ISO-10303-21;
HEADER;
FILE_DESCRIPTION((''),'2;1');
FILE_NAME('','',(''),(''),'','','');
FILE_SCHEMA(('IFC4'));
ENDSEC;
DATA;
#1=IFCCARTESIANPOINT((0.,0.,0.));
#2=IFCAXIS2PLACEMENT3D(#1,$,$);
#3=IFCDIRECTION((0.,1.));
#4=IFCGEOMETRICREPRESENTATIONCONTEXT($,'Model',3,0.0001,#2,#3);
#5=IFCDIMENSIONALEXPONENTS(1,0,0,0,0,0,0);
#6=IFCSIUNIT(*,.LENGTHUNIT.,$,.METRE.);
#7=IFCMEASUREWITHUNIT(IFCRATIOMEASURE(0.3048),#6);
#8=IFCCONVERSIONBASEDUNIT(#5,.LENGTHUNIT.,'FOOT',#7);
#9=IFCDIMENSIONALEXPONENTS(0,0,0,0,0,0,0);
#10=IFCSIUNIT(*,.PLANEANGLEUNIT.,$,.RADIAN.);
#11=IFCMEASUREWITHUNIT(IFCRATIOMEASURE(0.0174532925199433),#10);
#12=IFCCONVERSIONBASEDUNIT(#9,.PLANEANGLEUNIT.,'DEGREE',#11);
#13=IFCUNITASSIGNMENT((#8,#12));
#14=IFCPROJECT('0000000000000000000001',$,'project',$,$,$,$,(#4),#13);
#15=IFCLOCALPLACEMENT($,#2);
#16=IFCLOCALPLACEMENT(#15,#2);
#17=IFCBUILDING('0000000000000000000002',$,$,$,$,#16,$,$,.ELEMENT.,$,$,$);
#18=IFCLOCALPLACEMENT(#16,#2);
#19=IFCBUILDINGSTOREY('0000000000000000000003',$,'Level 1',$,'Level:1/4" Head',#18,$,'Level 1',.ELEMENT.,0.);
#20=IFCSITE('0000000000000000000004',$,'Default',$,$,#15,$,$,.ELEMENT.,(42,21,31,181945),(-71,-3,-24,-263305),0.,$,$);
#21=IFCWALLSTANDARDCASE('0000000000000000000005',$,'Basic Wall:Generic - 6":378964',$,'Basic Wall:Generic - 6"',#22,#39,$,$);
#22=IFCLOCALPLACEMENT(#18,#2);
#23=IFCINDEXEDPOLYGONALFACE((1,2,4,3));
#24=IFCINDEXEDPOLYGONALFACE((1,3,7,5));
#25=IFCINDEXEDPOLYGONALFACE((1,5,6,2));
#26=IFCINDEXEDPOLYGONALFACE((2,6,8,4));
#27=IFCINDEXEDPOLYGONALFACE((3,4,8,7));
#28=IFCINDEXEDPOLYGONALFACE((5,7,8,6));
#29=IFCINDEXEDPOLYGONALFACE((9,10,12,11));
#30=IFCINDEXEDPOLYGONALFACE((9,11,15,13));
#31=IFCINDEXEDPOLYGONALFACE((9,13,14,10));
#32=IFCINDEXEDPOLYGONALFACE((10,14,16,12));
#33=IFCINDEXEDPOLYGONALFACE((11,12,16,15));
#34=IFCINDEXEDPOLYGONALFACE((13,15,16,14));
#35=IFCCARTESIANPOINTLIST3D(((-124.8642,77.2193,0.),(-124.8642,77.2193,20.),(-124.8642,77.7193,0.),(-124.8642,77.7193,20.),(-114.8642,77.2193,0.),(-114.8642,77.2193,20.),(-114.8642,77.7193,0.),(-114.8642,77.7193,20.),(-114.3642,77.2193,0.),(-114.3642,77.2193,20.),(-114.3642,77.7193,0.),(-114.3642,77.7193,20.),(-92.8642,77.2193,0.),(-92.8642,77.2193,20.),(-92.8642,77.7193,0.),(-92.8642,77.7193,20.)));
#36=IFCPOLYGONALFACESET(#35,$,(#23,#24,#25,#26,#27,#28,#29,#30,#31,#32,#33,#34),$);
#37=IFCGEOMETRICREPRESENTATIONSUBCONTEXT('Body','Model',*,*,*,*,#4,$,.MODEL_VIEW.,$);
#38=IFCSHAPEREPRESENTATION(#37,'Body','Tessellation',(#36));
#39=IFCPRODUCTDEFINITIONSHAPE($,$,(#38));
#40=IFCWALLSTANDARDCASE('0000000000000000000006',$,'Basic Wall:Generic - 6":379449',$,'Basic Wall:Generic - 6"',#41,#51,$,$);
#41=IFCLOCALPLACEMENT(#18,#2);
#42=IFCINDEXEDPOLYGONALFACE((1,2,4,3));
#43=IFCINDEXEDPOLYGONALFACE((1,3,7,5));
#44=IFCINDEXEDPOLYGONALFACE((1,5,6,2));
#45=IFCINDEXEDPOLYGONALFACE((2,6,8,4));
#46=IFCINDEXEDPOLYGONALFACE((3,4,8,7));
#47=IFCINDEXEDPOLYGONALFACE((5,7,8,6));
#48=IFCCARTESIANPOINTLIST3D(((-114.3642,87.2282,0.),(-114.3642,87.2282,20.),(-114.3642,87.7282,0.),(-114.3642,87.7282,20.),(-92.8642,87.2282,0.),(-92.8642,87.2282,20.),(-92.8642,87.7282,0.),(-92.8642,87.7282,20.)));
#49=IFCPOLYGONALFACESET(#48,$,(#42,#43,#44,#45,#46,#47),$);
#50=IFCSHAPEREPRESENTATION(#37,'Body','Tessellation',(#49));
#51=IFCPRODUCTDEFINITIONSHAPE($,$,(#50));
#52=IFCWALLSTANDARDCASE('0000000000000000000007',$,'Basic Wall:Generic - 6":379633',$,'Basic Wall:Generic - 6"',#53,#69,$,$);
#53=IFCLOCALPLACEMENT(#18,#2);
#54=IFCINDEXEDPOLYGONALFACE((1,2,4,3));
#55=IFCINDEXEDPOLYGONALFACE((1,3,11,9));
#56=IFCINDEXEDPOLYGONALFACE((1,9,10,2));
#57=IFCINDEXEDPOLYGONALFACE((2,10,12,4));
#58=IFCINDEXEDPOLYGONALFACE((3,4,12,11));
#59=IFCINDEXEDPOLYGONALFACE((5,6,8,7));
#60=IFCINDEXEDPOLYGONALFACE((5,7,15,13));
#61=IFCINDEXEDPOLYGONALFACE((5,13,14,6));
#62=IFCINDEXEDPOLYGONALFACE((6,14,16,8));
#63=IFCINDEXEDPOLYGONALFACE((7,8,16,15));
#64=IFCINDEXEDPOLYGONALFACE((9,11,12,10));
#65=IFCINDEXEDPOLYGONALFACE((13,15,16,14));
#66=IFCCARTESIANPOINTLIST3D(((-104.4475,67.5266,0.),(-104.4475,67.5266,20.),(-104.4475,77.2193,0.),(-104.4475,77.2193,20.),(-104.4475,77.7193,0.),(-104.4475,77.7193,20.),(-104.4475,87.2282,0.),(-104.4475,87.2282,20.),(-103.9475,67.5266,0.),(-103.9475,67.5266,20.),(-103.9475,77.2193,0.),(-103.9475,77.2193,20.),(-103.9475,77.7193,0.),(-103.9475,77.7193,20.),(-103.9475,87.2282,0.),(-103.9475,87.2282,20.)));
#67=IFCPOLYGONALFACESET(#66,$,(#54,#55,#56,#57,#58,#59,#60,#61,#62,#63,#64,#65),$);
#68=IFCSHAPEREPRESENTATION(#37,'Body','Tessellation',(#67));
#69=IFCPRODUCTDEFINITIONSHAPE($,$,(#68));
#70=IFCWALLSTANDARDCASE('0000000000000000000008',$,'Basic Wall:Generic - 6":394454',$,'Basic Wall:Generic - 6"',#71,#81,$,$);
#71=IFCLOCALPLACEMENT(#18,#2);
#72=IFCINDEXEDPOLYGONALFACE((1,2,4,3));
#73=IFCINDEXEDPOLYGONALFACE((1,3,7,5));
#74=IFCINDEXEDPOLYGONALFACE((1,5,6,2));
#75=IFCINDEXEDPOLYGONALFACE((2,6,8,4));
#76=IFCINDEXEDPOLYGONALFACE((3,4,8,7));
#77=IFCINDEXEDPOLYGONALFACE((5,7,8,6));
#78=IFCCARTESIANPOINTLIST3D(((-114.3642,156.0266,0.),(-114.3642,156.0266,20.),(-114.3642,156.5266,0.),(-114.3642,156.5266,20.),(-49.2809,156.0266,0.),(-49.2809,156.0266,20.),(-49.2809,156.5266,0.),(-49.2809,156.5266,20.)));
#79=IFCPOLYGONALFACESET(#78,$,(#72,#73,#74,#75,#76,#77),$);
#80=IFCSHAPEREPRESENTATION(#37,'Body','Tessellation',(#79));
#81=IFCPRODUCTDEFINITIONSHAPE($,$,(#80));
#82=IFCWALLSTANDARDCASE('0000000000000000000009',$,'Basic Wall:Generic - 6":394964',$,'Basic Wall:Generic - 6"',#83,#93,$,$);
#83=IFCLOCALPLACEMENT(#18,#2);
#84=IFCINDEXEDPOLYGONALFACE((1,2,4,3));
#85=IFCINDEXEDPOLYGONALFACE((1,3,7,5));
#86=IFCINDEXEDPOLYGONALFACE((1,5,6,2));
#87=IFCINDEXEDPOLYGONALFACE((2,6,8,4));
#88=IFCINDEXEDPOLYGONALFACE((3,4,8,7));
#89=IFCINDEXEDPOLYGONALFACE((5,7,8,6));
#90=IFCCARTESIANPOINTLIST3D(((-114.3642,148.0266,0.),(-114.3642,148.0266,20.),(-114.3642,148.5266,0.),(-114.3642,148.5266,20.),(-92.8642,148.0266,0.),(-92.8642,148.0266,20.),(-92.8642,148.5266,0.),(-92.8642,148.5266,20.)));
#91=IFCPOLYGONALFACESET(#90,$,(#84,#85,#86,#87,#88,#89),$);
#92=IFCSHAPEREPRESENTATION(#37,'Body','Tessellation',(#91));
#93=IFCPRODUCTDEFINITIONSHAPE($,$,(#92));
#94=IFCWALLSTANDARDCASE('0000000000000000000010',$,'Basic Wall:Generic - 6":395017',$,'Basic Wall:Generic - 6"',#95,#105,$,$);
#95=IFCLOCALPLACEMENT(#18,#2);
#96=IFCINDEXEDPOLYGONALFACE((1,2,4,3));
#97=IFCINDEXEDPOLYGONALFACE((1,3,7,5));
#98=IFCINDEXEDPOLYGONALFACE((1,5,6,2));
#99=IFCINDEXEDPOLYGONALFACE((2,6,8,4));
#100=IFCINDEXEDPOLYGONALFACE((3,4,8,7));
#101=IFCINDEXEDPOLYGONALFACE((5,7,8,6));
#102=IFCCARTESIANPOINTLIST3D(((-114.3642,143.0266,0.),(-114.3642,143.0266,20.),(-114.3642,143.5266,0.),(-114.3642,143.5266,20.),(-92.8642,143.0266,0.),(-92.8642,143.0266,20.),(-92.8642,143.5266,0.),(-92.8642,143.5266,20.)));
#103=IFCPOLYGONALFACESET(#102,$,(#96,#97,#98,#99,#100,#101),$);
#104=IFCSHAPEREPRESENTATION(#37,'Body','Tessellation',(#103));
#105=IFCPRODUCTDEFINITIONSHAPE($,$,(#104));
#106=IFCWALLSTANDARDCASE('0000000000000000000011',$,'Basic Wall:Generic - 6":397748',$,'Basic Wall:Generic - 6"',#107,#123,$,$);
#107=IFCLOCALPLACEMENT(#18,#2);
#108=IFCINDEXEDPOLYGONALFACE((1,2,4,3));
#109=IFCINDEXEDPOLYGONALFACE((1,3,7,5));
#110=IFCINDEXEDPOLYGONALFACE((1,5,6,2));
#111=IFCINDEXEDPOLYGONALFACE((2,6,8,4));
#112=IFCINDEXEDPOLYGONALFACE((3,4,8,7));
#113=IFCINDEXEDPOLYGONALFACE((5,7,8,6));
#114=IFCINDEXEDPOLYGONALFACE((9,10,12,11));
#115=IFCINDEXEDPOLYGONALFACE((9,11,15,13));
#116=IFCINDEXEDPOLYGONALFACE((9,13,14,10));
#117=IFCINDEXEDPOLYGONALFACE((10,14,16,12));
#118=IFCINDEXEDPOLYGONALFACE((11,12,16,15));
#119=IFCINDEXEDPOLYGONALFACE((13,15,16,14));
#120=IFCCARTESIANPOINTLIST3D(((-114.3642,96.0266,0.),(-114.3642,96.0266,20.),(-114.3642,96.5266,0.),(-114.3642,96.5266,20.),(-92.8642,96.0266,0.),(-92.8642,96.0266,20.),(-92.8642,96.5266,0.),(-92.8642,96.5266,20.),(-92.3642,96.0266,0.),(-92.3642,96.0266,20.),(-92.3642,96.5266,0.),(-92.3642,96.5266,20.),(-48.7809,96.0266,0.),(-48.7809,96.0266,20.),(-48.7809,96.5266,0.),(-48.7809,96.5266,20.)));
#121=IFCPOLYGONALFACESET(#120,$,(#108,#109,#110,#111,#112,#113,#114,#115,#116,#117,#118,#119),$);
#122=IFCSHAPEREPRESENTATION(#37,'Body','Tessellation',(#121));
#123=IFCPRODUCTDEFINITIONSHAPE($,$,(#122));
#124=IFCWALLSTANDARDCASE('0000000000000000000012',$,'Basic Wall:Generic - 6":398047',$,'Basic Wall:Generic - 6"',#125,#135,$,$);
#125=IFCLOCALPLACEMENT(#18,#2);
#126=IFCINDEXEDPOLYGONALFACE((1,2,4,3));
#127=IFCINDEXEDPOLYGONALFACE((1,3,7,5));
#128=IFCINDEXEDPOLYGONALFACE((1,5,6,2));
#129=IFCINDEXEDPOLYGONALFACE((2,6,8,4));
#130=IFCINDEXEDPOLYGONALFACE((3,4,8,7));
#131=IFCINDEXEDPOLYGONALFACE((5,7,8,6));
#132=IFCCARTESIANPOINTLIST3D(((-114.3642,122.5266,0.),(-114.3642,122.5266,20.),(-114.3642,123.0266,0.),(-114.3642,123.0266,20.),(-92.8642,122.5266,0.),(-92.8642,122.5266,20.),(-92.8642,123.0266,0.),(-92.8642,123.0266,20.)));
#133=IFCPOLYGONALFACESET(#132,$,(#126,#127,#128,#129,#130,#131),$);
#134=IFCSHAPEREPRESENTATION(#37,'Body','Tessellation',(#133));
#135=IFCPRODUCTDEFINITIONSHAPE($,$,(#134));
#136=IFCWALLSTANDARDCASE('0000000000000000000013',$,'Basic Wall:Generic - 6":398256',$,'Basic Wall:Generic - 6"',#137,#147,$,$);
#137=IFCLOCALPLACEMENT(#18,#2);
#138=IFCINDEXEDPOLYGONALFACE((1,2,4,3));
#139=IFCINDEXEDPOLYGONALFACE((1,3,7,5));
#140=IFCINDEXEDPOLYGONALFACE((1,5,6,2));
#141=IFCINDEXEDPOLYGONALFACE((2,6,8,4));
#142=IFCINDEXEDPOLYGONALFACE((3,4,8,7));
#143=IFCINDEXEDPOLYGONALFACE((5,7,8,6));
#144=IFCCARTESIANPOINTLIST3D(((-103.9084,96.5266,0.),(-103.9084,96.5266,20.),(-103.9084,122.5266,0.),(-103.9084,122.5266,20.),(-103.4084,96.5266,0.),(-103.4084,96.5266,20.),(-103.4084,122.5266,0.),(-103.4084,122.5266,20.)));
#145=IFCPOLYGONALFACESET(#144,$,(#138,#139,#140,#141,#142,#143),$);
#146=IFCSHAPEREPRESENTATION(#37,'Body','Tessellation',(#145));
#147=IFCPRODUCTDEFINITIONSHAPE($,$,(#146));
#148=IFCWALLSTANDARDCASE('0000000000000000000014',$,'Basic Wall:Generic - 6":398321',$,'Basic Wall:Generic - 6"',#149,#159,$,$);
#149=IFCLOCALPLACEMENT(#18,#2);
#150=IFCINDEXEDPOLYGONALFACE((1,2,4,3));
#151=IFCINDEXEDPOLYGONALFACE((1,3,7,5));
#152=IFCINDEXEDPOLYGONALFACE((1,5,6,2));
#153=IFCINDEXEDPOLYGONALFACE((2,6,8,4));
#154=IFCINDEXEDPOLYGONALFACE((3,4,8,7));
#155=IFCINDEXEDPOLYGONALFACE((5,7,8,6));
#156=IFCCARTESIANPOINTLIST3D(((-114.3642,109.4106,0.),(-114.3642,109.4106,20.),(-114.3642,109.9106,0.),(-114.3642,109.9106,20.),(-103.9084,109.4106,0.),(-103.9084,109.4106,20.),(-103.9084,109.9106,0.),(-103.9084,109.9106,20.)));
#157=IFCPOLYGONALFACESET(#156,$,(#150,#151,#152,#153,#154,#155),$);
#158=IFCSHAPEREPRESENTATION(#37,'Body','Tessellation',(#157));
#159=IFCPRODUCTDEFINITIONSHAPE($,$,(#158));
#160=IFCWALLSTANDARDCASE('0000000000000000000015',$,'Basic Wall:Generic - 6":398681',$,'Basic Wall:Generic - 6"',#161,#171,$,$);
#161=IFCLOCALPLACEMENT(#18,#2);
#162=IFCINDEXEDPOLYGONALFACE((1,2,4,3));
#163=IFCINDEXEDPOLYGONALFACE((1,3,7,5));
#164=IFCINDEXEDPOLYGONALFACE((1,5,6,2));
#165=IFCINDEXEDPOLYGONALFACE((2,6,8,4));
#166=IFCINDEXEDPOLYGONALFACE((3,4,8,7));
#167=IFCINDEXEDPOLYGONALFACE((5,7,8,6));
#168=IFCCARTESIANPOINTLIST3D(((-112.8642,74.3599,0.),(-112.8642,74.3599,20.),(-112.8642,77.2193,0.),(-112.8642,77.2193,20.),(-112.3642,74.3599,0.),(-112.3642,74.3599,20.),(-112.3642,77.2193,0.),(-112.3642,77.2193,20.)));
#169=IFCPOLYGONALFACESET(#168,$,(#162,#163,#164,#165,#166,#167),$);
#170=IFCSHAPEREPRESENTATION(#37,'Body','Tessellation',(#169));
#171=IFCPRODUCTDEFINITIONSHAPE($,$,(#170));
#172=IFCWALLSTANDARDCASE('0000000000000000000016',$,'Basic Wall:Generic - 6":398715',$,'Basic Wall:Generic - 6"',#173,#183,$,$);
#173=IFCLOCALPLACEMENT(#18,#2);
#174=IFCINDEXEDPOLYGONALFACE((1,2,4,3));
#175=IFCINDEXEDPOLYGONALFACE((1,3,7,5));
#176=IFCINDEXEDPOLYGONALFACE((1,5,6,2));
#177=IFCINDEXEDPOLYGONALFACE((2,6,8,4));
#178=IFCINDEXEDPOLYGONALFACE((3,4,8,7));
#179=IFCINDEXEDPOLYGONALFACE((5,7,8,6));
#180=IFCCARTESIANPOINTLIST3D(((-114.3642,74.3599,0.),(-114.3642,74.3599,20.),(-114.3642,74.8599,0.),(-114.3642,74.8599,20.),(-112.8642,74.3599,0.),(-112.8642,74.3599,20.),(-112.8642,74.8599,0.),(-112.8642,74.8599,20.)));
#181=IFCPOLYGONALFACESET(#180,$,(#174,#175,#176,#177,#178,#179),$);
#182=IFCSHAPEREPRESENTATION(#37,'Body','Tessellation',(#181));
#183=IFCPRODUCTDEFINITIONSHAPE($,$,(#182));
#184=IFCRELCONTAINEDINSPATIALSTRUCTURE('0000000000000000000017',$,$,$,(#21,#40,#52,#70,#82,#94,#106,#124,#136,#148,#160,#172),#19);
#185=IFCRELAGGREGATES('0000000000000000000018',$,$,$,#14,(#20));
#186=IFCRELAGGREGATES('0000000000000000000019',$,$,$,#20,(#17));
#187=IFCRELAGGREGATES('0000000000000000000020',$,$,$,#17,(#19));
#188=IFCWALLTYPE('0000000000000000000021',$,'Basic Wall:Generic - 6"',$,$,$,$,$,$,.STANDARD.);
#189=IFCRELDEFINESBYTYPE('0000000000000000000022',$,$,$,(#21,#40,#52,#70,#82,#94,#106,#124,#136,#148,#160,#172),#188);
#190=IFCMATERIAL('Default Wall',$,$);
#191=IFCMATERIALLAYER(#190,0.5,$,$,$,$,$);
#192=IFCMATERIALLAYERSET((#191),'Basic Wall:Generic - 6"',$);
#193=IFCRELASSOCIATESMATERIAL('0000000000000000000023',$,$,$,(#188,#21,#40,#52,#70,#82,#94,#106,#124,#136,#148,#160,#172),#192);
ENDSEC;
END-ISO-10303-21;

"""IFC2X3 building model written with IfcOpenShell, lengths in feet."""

from ifc_helpers import new_model, entity, si_unit, converted_unit, direction, frame, frame_2d, origin, origin_2d_with_axis, place, context, subcontext, project, spatial, rectangle, extrude, material, layer, layer_set, layer_usage, type_object, element, save


model = new_model("IFC2X3")

# Units and contexts
model_context = context("Model", 3, precision=0.0001, world=origin(), true_north=direction((0.0, 1.0)))
body_context = subcontext(model_context, "Body", "Model", "MODEL_VIEW")
ifc_project = project(units=[converted_unit("LENGTHUNIT", "FOOT", entity("IfcRatioMeasure", 0.3048), si_unit("LENGTHUNIT", "METRE"), dimensions=[1, 0, 0, 0, 0, 0, 0]), converted_unit("PLANEANGLEUNIT", "DEGREE", entity("IfcRatioMeasure", 0.0174532925199433), si_unit("PLANEANGLEUNIT", "RADIAN"), dimensions=[0, 0, 0, 0, 0, 0, 0])], contexts=[model_context])

# Site, building, storey
site_placement = place(None, origin())
site = spatial("IfcSite", under=ifc_project, at=site_placement, Name="Default", CompositionType="ELEMENT", RefLatitude=(42, 21, 31, 181945), RefLongitude=(-71, -3, -24, -263305), RefElevation=0.0)
building_placement = place(site_placement, origin())
building = spatial("IfcBuilding", under=site, at=building_placement, CompositionType="ELEMENT")
storey_placement = place(building_placement, origin())
storey = spatial("IfcBuildingStorey", under=building, at=storey_placement, Name="Level 1", ObjectType="Level:1/4\" Head", LongName="Level 1", CompositionType="ELEMENT", Elevation=0.0)

# Shared definitions
ifc_material = material(Name="Default Wall")
ifc_layer_1 = layer(ifc_material, 0.5)
ifc_layer_set_1 = layer_set([ifc_layer_1], Name="Basic Wall:Generic - 6\"")
wall_type_1 = type_object("IfcWallType", Name="Basic Wall:Generic - 6\"", PredefinedType="STANDARD", material=ifc_layer_set_1)

# Wall, opening
ifc_layer_usage_1 = layer_usage(ifc_layer_set_1, "AXIS2", "NEGATIVE", 0.25)
wall_1_placement = place(storey_placement, frame((-124.8642, 77.4693, 0.0)))
wall_1 = element("IfcWallStandardCase", 1, at=wall_1_placement, inside=storey, type_object=wall_type_1, material=ifc_layer_usage_1, Name="Basic Wall:Generic - 6\":378964", ObjectType="Basic Wall:Generic - 6\"", context=body_context, shape_type="SweptSolid", body=[
    extrude(rectangle(XDim=32.0, YDim=0.5, at=frame_2d((16.0, 0.0), x_axis=(-1.0, 0.0))), origin(), (0.0, 0.0, 1.0), 20.0),
])
opening_1_placement = place(storey_placement, frame((-124.8642, 77.4693, 0.0)))
element("IfcOpeningElement", 2, at=opening_1_placement, cuts=wall_1, ObjectType="Opening", context=body_context, shape_type="SweptSolid", body=[
    extrude(rectangle(XDim=20.0, YDim=0.5, at=origin_2d_with_axis()), frame((10.0, 0.0, 10.0), z_axis=(1.0, 0.0, 0.0), x_axis=(0.0, 0.0, -1.0)), (0.0, 0.0, 1.0), 0.5),
])

# Wall
ifc_layer_usage_2 = layer_usage(ifc_layer_set_1, "AXIS2", "NEGATIVE", 0.25)
wall_2_placement = place(storey_placement, frame((-114.3642, 87.4782, 0.0)))
element("IfcWallStandardCase", 3, at=wall_2_placement, inside=storey, type_object=wall_type_1, material=ifc_layer_usage_2, Name="Basic Wall:Generic - 6\":379449", ObjectType="Basic Wall:Generic - 6\"", context=body_context, shape_type="SweptSolid", body=[
    extrude(rectangle(XDim=21.5, YDim=0.5, at=frame_2d((10.75, 0.0), x_axis=(-1.0, 0.0))), origin(), (0.0, 0.0, 1.0), 20.0),
])

# Wall, opening
ifc_layer_usage_3 = layer_usage(ifc_layer_set_1, "AXIS2", "NEGATIVE", 0.25)
wall_3_placement = place(storey_placement, frame((-104.1975, 67.5266, 0.0), z_axis=(0.0, 0.0, 1.0), x_axis=(0.0, 1.0, 0.0)))
wall_3 = element("IfcWallStandardCase", 4, at=wall_3_placement, inside=storey, type_object=wall_type_1, material=ifc_layer_usage_3, Name="Basic Wall:Generic - 6\":379633", ObjectType="Basic Wall:Generic - 6\"", context=body_context, shape_type="SweptSolid", body=[
    extrude(rectangle(XDim=19.7016, YDim=0.5, at=frame_2d((9.8508, 0.0), x_axis=(-1.0, 0.0))), origin(), (0.0, 0.0, 1.0), 20.0),
])
opening_2_placement = place(storey_placement, frame((-104.1975, 67.5266, 0.0), z_axis=(0.0, 0.0, 1.0), x_axis=(0.0, 1.0, 0.0)))
element("IfcOpeningElement", 5, at=opening_2_placement, cuts=wall_3, ObjectType="Opening", context=body_context, shape_type="SweptSolid", body=[
    extrude(rectangle(XDim=20.0, YDim=0.5, at=origin_2d_with_axis()), frame((9.6927, 0.0, 10.0), z_axis=(1.0, 0.0, 0.0), x_axis=(0.0, 0.0, -1.0)), (0.0, 0.0, 1.0), 0.5),
])

# Walls
ifc_layer_usage_4 = layer_usage(ifc_layer_set_1, "AXIS2", "NEGATIVE", 0.25)
wall_4_placement = place(storey_placement, frame((-114.3642, 156.2766, 0.0)))
element("IfcWallStandardCase", 6, at=wall_4_placement, inside=storey, type_object=wall_type_1, material=ifc_layer_usage_4, Name="Basic Wall:Generic - 6\":394454", ObjectType="Basic Wall:Generic - 6\"", context=body_context, shape_type="SweptSolid", body=[
    extrude(rectangle(XDim=65.0833, YDim=0.5, at=frame_2d((32.5417, 0.0), x_axis=(-1.0, 0.0))), origin(), (0.0, 0.0, 1.0), 20.0),
])
ifc_layer_usage_5 = layer_usage(ifc_layer_set_1, "AXIS2", "NEGATIVE", 0.25)
wall_5_placement = place(storey_placement, frame((-114.3642, 148.2766, 0.0)))
element("IfcWallStandardCase", 7, at=wall_5_placement, inside=storey, type_object=wall_type_1, material=ifc_layer_usage_5, Name="Basic Wall:Generic - 6\":394964", ObjectType="Basic Wall:Generic - 6\"", context=body_context, shape_type="SweptSolid", body=[
    extrude(rectangle(XDim=21.5, YDim=0.5, at=frame_2d((10.75, 0.0), x_axis=(-1.0, 0.0))), origin(), (0.0, 0.0, 1.0), 20.0),
])
ifc_layer_usage_6 = layer_usage(ifc_layer_set_1, "AXIS2", "NEGATIVE", 0.25)
wall_6_placement = place(storey_placement, frame((-114.3642, 143.2766, 0.0)))
element("IfcWallStandardCase", 8, at=wall_6_placement, inside=storey, type_object=wall_type_1, material=ifc_layer_usage_6, Name="Basic Wall:Generic - 6\":395017", ObjectType="Basic Wall:Generic - 6\"", context=body_context, shape_type="SweptSolid", body=[
    extrude(rectangle(XDim=21.5, YDim=0.5, at=frame_2d((10.75, 0.0), x_axis=(-1.0, 0.0))), origin(), (0.0, 0.0, 1.0), 20.0),
])

# Wall, opening
ifc_layer_usage_7 = layer_usage(ifc_layer_set_1, "AXIS2", "NEGATIVE", 0.25)
wall_7_placement = place(storey_placement, frame((-114.3642, 96.2766, 0.0)))
wall_7 = element("IfcWallStandardCase", 9, at=wall_7_placement, inside=storey, type_object=wall_type_1, material=ifc_layer_usage_7, Name="Basic Wall:Generic - 6\":397748", ObjectType="Basic Wall:Generic - 6\"", context=body_context, shape_type="SweptSolid", body=[
    extrude(rectangle(XDim=65.5833, YDim=0.5, at=frame_2d((32.7917, 0.0), x_axis=(-1.0, 0.0))), origin(), (0.0, 0.0, 1.0), 20.0),
])
opening_3_placement = place(storey_placement, frame((-114.3642, 96.2766, 0.0)))
element("IfcOpeningElement", 10, at=opening_3_placement, cuts=wall_7, ObjectType="Opening", context=body_context, shape_type="SweptSolid", body=[
    extrude(rectangle(XDim=20.0, YDim=0.5, at=origin_2d_with_axis()), frame((21.5, 0.0, 10.0), z_axis=(1.0, 0.0, 0.0), x_axis=(0.0, 0.0, -1.0)), (0.0, 0.0, 1.0), 0.5),
])

# Walls
ifc_layer_usage_8 = layer_usage(ifc_layer_set_1, "AXIS2", "NEGATIVE", 0.25)
wall_8_placement = place(storey_placement, frame((-114.3642, 122.7766, 0.0)))
element("IfcWallStandardCase", 11, at=wall_8_placement, inside=storey, type_object=wall_type_1, material=ifc_layer_usage_8, Name="Basic Wall:Generic - 6\":398047", ObjectType="Basic Wall:Generic - 6\"", context=body_context, shape_type="SweptSolid", body=[
    extrude(rectangle(XDim=21.5, YDim=0.5, at=frame_2d((10.75, 0.0), x_axis=(-1.0, 0.0))), origin(), (0.0, 0.0, 1.0), 20.0),
])
ifc_layer_usage_9 = layer_usage(ifc_layer_set_1, "AXIS2", "NEGATIVE", 0.25)
wall_9_placement = place(storey_placement, frame((-103.6584, 96.5266, 0.0), z_axis=(0.0, 0.0, 1.0), x_axis=(0.0, 1.0, 0.0)))
element("IfcWallStandardCase", 12, at=wall_9_placement, inside=storey, type_object=wall_type_1, material=ifc_layer_usage_9, Name="Basic Wall:Generic - 6\":398256", ObjectType="Basic Wall:Generic - 6\"", context=body_context, shape_type="SweptSolid", body=[
    extrude(rectangle(XDim=26.0, YDim=0.5, at=frame_2d((13.0, 0.0), x_axis=(-1.0, 0.0))), origin(), (0.0, 0.0, 1.0), 20.0),
])
ifc_layer_usage_10 = layer_usage(ifc_layer_set_1, "AXIS2", "NEGATIVE", 0.25)
wall_10_placement = place(storey_placement, frame((-114.3642, 109.6606, 0.0)))
element("IfcWallStandardCase", 13, at=wall_10_placement, inside=storey, type_object=wall_type_1, material=ifc_layer_usage_10, Name="Basic Wall:Generic - 6\":398321", ObjectType="Basic Wall:Generic - 6\"", context=body_context, shape_type="SweptSolid", body=[
    extrude(rectangle(XDim=10.4558, YDim=0.5, at=frame_2d((5.2279, 0.0), x_axis=(-1.0, 0.0))), origin(), (0.0, 0.0, 1.0), 20.0),
])
ifc_layer_usage_11 = layer_usage(ifc_layer_set_1, "AXIS2", "NEGATIVE", 0.25)
wall_11_placement = place(storey_placement, frame((-112.6142, 77.2193, 0.0), z_axis=(0.0, 0.0, 1.0), x_axis=(0.0, -1.0, 0.0)))
element("IfcWallStandardCase", 14, at=wall_11_placement, inside=storey, type_object=wall_type_1, material=ifc_layer_usage_11, Name="Basic Wall:Generic - 6\":398681", ObjectType="Basic Wall:Generic - 6\"", context=body_context, shape_type="SweptSolid", body=[
    extrude(rectangle(XDim=2.8594, YDim=0.5, at=frame_2d((1.4297, 0.0), x_axis=(-1.0, 0.0))), origin(), (0.0, 0.0, 1.0), 20.0),
])
ifc_layer_usage_12 = layer_usage(ifc_layer_set_1, "AXIS2", "NEGATIVE", 0.25)
wall_12_placement = place(storey_placement, frame((-112.8642, 74.6099, 0.0), z_axis=(0.0, 0.0, 1.0), x_axis=(-1.0, 0.0, 0.0)))
element("IfcWallStandardCase", 15, at=wall_12_placement, inside=storey, type_object=wall_type_1, material=ifc_layer_usage_12, Name="Basic Wall:Generic - 6\":398715", ObjectType="Basic Wall:Generic - 6\"", context=body_context, shape_type="SweptSolid", body=[
    extrude(rectangle(XDim=1.5, YDim=0.5, at=frame_2d((0.75, 0.0), x_axis=(-1.0, 0.0))), origin(), (0.0, 0.0, 1.0), 20.0),
])

save(model, "model.ifc")
